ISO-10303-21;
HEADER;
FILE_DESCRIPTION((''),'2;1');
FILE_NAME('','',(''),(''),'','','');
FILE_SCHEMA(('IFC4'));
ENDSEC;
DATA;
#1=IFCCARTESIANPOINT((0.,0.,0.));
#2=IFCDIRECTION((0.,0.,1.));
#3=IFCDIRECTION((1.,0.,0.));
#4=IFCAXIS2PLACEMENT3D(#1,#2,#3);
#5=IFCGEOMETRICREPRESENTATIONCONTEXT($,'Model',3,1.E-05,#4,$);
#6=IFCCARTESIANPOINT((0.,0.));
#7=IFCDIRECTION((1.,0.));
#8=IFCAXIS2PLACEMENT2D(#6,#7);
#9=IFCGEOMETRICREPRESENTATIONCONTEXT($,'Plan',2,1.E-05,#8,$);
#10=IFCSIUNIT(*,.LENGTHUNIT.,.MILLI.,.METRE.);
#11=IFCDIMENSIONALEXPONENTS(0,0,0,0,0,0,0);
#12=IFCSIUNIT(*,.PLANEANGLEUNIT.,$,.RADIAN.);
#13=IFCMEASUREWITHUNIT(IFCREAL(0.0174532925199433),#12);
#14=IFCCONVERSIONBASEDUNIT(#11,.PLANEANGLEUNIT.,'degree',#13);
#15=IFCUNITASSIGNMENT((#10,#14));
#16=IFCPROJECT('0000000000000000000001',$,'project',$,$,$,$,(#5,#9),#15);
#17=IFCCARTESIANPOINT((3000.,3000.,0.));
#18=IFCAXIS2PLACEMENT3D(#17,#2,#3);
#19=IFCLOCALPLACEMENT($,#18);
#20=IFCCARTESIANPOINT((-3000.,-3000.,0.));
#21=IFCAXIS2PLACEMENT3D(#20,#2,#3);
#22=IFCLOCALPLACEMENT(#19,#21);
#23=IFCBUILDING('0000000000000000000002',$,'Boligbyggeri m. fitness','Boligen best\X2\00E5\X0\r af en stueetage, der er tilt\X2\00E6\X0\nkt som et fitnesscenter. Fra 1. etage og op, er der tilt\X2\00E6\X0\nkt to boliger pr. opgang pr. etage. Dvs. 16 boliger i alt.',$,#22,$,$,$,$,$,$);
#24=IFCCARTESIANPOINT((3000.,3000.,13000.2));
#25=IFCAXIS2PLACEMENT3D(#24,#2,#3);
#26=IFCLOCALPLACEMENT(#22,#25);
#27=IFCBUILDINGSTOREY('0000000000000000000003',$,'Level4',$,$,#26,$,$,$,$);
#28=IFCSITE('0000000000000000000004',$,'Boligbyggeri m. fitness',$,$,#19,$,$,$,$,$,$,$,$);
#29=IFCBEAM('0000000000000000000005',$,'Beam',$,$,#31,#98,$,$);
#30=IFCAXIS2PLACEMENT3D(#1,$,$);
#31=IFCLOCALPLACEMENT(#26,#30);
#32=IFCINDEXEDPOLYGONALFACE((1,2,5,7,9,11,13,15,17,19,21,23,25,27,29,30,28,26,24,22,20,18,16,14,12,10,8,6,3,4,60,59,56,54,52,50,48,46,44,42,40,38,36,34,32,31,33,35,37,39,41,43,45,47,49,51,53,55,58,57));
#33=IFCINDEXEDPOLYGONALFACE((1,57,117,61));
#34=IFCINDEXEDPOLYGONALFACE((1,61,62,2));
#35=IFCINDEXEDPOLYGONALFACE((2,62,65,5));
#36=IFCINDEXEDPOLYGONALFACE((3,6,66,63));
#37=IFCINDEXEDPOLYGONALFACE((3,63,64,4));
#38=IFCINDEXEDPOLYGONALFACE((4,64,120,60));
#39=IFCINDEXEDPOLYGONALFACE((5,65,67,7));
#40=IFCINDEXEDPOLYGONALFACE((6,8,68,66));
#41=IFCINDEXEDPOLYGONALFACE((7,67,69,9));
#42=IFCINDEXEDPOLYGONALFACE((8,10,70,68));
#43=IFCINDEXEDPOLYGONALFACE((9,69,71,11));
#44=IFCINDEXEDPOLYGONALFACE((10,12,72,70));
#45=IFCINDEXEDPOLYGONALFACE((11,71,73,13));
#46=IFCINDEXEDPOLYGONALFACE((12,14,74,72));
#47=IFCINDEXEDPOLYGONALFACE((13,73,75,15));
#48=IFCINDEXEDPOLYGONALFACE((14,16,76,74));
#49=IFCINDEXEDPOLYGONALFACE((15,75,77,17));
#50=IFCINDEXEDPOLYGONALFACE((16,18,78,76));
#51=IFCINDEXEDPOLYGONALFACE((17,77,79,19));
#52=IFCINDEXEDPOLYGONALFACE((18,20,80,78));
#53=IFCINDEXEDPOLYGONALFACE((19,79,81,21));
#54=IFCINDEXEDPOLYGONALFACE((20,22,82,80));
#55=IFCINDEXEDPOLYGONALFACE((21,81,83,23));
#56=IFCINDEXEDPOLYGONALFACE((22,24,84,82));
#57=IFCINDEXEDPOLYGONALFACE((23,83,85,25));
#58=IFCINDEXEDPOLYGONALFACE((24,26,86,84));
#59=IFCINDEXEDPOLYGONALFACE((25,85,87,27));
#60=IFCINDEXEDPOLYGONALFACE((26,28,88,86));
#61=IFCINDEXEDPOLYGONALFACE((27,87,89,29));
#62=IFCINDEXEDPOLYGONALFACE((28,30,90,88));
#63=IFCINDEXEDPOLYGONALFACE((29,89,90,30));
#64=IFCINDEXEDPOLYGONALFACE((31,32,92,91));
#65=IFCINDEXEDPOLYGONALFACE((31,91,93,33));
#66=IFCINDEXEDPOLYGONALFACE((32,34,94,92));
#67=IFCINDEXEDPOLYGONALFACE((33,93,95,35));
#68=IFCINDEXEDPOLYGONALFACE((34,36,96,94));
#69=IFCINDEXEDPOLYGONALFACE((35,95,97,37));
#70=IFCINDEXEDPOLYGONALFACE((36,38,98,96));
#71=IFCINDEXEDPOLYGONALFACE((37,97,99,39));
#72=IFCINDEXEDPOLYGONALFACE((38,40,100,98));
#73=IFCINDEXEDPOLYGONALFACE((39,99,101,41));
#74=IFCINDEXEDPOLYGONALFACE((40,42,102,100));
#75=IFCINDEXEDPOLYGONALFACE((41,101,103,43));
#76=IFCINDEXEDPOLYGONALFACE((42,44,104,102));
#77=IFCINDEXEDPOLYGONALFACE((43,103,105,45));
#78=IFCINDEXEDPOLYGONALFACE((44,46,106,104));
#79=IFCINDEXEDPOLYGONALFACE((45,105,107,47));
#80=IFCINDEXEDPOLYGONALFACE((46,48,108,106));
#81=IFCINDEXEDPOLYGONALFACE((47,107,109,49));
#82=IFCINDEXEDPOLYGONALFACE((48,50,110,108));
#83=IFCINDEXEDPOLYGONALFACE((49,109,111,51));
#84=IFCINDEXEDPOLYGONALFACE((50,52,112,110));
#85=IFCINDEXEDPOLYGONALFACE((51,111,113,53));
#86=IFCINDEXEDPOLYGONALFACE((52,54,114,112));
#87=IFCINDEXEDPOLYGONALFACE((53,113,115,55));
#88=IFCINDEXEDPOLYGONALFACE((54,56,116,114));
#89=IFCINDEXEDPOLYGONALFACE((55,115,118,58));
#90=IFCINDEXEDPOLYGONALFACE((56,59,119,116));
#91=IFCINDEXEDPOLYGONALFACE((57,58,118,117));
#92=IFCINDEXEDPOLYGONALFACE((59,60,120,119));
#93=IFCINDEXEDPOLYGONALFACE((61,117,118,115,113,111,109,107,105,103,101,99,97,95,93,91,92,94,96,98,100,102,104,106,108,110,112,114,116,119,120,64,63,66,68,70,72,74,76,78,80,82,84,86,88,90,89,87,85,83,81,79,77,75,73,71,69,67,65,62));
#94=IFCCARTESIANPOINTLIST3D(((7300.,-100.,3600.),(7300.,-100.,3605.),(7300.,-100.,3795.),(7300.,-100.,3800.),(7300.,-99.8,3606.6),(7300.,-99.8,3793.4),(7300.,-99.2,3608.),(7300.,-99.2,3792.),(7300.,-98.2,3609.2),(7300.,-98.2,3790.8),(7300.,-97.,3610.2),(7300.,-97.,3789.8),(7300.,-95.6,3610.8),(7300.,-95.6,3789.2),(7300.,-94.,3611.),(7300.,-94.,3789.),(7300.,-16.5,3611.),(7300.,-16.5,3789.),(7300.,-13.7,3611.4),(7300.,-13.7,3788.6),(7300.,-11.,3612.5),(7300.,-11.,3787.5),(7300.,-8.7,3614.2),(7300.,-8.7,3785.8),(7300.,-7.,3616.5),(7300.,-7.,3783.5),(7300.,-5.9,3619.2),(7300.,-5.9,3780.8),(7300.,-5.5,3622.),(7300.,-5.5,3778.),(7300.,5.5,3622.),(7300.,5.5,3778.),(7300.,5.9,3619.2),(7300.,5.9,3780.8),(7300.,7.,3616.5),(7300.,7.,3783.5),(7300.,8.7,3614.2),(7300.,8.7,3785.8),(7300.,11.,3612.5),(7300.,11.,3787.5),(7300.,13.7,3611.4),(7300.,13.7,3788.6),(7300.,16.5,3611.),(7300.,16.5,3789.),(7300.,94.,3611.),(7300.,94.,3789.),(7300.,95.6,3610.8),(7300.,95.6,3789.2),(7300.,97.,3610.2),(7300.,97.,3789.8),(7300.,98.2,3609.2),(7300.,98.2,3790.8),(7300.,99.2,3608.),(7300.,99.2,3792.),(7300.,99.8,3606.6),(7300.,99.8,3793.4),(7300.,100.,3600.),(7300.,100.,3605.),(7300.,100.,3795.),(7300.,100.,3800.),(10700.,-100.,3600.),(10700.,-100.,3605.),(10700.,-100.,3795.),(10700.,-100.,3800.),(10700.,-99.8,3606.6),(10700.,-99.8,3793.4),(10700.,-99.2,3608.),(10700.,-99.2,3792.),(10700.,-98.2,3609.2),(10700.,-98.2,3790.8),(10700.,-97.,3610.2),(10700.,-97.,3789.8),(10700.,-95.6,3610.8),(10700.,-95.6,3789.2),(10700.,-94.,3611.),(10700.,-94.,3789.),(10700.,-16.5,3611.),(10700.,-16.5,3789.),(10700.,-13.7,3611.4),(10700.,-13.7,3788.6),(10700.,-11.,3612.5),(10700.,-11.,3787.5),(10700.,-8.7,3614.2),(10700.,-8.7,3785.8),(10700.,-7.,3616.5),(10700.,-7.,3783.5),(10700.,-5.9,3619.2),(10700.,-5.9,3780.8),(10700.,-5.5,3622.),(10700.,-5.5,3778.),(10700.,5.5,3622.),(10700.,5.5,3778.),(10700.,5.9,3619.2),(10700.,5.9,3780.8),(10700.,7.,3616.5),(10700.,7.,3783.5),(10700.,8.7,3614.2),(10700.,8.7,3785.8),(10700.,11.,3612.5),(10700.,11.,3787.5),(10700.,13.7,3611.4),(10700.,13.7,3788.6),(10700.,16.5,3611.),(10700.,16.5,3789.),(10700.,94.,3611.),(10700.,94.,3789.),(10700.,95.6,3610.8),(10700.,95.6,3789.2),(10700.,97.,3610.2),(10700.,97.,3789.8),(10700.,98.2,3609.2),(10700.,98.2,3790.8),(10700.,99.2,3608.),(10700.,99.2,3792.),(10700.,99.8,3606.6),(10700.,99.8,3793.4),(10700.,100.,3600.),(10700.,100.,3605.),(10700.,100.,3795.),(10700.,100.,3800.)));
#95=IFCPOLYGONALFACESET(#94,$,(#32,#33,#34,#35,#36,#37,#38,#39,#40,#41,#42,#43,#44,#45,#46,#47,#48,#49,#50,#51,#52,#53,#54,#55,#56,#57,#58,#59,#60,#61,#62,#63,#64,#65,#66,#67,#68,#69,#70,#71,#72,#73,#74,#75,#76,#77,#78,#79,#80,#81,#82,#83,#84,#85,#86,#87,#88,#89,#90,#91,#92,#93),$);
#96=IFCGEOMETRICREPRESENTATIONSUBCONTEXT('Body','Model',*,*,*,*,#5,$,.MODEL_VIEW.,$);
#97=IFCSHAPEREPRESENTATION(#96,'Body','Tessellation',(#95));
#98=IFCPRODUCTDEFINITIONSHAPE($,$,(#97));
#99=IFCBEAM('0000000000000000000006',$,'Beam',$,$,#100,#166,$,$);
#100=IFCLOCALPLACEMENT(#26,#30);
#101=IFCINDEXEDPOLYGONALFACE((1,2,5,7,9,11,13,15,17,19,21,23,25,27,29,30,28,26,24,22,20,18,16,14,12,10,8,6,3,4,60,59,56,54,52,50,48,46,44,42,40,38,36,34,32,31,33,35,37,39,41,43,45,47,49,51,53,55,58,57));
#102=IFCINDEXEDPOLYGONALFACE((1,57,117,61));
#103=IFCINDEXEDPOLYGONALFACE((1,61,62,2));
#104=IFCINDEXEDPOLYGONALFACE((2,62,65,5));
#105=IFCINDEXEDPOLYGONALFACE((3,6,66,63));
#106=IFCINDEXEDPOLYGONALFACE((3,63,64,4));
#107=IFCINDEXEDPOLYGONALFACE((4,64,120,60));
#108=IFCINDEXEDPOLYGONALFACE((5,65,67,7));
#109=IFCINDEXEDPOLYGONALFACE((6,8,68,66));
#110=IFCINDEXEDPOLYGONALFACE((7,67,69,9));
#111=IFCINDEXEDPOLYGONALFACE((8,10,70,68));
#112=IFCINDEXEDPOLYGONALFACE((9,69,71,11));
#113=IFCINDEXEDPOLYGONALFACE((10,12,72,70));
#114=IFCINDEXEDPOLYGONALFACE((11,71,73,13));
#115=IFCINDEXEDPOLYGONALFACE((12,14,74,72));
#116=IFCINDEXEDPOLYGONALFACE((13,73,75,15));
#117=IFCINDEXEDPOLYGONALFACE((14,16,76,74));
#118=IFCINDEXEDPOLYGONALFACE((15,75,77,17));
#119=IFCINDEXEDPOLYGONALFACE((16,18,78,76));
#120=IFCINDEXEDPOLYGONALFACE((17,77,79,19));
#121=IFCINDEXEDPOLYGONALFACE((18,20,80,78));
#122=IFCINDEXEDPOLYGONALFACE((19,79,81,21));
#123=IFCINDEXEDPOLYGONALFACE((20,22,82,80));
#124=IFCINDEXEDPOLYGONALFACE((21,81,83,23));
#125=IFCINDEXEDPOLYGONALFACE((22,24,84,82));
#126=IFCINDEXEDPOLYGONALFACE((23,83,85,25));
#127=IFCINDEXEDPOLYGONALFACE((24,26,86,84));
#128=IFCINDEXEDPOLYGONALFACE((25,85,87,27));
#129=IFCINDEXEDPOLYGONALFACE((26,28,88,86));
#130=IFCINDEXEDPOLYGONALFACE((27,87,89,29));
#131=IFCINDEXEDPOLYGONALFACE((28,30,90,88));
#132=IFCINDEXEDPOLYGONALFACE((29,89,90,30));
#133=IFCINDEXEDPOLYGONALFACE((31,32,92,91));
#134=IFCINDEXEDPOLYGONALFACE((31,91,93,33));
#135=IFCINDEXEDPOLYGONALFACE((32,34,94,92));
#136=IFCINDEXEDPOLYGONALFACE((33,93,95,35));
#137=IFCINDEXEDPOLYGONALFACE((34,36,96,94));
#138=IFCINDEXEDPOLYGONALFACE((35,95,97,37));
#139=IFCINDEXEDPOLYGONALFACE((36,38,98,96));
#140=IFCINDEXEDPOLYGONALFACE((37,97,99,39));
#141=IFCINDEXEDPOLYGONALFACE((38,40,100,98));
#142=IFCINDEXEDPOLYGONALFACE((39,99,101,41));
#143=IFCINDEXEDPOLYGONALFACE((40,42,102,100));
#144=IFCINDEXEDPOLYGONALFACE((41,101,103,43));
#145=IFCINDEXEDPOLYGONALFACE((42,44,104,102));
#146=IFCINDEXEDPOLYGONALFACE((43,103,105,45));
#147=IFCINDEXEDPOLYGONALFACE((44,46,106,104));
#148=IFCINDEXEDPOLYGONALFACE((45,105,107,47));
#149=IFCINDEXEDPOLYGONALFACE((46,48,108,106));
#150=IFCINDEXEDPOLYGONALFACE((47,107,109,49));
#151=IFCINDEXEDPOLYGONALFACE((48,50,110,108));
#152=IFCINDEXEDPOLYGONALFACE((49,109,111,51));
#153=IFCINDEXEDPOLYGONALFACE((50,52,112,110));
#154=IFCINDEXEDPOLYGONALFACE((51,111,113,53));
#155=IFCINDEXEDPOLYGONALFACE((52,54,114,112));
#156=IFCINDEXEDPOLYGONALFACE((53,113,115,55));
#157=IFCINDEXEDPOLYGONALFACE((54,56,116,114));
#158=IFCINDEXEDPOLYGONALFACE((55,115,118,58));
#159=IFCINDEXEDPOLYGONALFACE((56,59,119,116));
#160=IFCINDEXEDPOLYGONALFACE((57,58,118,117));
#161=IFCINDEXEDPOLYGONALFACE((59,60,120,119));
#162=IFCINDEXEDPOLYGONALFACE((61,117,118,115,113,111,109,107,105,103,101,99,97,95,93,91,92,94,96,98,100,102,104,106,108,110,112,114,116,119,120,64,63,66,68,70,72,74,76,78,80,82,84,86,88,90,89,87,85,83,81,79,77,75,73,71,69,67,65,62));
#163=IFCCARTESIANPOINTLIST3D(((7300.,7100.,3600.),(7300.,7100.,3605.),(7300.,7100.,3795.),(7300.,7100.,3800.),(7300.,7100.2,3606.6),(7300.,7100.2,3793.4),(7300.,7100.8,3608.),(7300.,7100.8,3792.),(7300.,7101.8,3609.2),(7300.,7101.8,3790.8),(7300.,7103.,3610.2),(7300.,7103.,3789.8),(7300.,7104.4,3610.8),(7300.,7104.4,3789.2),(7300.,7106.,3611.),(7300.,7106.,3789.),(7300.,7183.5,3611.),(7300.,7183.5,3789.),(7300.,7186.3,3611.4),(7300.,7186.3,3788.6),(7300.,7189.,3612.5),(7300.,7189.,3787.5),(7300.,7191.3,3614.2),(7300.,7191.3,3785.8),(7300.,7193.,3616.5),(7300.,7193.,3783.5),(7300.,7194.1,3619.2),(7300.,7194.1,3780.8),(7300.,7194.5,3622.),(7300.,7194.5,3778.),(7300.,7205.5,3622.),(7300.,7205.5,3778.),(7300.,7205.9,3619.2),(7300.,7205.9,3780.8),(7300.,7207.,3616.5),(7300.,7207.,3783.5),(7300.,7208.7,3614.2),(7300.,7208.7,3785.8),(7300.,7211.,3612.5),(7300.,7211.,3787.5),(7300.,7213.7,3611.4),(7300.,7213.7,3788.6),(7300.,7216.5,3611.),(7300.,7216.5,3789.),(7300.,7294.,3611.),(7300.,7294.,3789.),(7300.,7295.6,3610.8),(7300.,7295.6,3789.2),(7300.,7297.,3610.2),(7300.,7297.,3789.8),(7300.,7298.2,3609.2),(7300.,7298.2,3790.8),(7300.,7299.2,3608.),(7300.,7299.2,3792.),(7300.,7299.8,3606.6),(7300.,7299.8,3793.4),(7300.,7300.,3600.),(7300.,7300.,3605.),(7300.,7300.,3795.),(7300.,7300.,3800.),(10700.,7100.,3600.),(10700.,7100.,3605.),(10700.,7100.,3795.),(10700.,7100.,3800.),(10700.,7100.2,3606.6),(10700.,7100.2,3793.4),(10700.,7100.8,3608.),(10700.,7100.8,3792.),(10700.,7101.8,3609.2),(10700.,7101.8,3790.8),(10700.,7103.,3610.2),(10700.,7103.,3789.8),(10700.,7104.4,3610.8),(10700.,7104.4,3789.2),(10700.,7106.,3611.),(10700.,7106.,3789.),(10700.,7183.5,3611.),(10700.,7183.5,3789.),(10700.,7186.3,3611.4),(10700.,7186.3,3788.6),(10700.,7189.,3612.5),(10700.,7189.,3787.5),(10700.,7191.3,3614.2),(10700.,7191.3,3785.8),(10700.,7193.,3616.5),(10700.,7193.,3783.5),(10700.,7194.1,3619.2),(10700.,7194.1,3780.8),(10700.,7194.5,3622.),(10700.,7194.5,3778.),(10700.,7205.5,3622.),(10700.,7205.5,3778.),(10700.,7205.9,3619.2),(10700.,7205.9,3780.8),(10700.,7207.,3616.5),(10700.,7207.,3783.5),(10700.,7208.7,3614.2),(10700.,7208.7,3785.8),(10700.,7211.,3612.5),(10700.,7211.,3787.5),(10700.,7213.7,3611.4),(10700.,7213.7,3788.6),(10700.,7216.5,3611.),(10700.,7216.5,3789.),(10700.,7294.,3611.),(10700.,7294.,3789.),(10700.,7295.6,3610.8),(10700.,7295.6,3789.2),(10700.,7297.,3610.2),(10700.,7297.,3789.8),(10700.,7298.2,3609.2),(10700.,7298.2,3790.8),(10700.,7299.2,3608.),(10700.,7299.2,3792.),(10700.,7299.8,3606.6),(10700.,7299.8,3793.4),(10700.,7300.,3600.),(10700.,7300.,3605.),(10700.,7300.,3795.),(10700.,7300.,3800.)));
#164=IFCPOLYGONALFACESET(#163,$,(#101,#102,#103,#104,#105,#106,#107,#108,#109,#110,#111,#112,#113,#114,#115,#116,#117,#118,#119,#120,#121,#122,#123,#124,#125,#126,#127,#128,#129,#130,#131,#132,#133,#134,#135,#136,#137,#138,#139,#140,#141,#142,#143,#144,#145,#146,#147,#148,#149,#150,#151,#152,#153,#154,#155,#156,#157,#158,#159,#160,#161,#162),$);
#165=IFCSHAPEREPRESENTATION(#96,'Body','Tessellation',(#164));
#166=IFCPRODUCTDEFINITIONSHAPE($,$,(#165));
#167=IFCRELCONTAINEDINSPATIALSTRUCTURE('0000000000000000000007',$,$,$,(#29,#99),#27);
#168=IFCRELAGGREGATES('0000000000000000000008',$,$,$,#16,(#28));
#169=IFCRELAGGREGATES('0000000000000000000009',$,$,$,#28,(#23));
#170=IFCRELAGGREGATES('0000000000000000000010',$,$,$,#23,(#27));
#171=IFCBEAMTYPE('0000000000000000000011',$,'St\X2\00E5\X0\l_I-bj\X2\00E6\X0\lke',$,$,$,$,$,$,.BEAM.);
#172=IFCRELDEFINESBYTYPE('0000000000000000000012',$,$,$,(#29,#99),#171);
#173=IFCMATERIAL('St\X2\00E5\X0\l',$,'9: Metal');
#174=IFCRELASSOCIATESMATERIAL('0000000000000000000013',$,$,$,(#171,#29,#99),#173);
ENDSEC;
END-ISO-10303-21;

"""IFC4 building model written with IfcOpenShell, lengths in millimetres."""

from ifc_helpers import new_model, entity, si_unit, converted_unit, frame, origin_with_axes, origin_2d_with_axis, place, context, subcontext, project, spatial, i_section, extrude, material, material_profile, profile_set, profile_usage, type_object, element, save


model = new_model("IFC4")

# Units and contexts
model_context = context("Model", 3, precision=1e-05, world=origin_with_axes())
plan_context = context("Plan", 2, precision=1e-05, world=origin_2d_with_axis())
body_context = subcontext(model_context, "Body", "Model", "MODEL_VIEW")
ifc_project = project(units=[si_unit("LENGTHUNIT", "METRE", prefix="MILLI"), converted_unit("PLANEANGLEUNIT", "degree", entity("IfcReal", 0.0174532925199433), si_unit("PLANEANGLEUNIT", "RADIAN"), dimensions=[0, 0, 0, 0, 0, 0, 0])], contexts=[model_context, plan_context])

# Site, building, storey
site_placement = place(None, frame((3000.0, 3000.0, 0.0), z_axis=(0.0, 0.0, 1.0), x_axis=(1.0, 0.0, 0.0)))
site = spatial("IfcSite", under=ifc_project, at=site_placement, Name="Boligbyggeri m. fitness")
building_placement = place(site_placement, frame((-3000.0, -3000.0, 0.0), z_axis=(0.0, 0.0, 1.0), x_axis=(1.0, 0.0, 0.0)))
building = spatial("IfcBuilding", under=site, at=building_placement, Name="Boligbyggeri m. fitness", Description="Boligen består af en stueetage, der er tiltænkt som et fitnesscenter. Fra 1. etage og op, er der tiltænkt to boliger pr. opgang pr. etage. Dvs. 16 boliger i alt.")
storey_placement = place(building_placement, frame((3000.0, 3000.0, 13000.2), z_axis=(0.0, 0.0, 1.0), x_axis=(1.0, 0.0, 0.0)))
storey = spatial("IfcBuildingStorey", under=building, at=storey_placement, Name="Level4")

# Beams
ifc_material_1 = material(Name="Stål", Category="9: Metal")
ifc_material_profile_1 = material_profile(ifc_material_1, i_section(OverallWidth=200.0, OverallDepth=200.0, WebThickness=11.0, FlangeThickness=11.0, FilletRadius=11.0, FlangeEdgeRadius=6.0), Name="Stål", Category="9: Metal")
ifc_profile_set_1 = profile_set([ifc_material_profile_1], Name="NY_I-Profil")
beam_type = type_object("IfcBeamType", Name="Stål_I-bjælke", PredefinedType="BEAM", material=ifc_profile_set_1)
ifc_profile_usage_1 = profile_usage(ifc_profile_set_1, cardinal=7)
beam_1_placement = place(storey_placement, frame((7300.0, 100.0, 3800.0), z_axis=(1.0, 0.0, 0.0), x_axis=(0.0, 1.0, 0.0)))
element("IfcBeam", 1, at=beam_1_placement, inside=storey, type_object=beam_type, material=ifc_profile_usage_1, Name="Beam", context=body_context, shape_type="SweptSolid", body=[
    extrude(i_section(OverallWidth=200.0, OverallDepth=200.0, WebThickness=11.0, FlangeThickness=11.0, FilletRadius=11.0, FlangeEdgeRadius=6.0), frame((-100.0, -100.0, 0.0), z_axis=(0.0, 0.0, 1.0), x_axis=(1.0, 0.0, 0.0)), (0.0, 0.0, 1.0), 3400.0),
])
ifc_profile_usage_2 = profile_usage(ifc_profile_set_1, cardinal=7)
beam_2_placement = place(storey_placement, frame((7300.0, 7300.0, 3800.0), z_axis=(1.0, 0.0, 0.0), x_axis=(0.0, 1.0, 0.0)))
element("IfcBeam", 2, at=beam_2_placement, inside=storey, type_object=beam_type, material=ifc_profile_usage_2, Name="Beam", context=body_context, shape_type="SweptSolid", body=[
    extrude(i_section(OverallWidth=200.0, OverallDepth=200.0, WebThickness=11.0, FlangeThickness=11.0, FilletRadius=11.0, FlangeEdgeRadius=6.0), frame((-100.0, -100.0, 0.0), z_axis=(0.0, 0.0, 1.0), x_axis=(1.0, 0.0, 0.0)), (0.0, 0.0, 1.0), 3400.0),
])

save(model, "model.ifc")
